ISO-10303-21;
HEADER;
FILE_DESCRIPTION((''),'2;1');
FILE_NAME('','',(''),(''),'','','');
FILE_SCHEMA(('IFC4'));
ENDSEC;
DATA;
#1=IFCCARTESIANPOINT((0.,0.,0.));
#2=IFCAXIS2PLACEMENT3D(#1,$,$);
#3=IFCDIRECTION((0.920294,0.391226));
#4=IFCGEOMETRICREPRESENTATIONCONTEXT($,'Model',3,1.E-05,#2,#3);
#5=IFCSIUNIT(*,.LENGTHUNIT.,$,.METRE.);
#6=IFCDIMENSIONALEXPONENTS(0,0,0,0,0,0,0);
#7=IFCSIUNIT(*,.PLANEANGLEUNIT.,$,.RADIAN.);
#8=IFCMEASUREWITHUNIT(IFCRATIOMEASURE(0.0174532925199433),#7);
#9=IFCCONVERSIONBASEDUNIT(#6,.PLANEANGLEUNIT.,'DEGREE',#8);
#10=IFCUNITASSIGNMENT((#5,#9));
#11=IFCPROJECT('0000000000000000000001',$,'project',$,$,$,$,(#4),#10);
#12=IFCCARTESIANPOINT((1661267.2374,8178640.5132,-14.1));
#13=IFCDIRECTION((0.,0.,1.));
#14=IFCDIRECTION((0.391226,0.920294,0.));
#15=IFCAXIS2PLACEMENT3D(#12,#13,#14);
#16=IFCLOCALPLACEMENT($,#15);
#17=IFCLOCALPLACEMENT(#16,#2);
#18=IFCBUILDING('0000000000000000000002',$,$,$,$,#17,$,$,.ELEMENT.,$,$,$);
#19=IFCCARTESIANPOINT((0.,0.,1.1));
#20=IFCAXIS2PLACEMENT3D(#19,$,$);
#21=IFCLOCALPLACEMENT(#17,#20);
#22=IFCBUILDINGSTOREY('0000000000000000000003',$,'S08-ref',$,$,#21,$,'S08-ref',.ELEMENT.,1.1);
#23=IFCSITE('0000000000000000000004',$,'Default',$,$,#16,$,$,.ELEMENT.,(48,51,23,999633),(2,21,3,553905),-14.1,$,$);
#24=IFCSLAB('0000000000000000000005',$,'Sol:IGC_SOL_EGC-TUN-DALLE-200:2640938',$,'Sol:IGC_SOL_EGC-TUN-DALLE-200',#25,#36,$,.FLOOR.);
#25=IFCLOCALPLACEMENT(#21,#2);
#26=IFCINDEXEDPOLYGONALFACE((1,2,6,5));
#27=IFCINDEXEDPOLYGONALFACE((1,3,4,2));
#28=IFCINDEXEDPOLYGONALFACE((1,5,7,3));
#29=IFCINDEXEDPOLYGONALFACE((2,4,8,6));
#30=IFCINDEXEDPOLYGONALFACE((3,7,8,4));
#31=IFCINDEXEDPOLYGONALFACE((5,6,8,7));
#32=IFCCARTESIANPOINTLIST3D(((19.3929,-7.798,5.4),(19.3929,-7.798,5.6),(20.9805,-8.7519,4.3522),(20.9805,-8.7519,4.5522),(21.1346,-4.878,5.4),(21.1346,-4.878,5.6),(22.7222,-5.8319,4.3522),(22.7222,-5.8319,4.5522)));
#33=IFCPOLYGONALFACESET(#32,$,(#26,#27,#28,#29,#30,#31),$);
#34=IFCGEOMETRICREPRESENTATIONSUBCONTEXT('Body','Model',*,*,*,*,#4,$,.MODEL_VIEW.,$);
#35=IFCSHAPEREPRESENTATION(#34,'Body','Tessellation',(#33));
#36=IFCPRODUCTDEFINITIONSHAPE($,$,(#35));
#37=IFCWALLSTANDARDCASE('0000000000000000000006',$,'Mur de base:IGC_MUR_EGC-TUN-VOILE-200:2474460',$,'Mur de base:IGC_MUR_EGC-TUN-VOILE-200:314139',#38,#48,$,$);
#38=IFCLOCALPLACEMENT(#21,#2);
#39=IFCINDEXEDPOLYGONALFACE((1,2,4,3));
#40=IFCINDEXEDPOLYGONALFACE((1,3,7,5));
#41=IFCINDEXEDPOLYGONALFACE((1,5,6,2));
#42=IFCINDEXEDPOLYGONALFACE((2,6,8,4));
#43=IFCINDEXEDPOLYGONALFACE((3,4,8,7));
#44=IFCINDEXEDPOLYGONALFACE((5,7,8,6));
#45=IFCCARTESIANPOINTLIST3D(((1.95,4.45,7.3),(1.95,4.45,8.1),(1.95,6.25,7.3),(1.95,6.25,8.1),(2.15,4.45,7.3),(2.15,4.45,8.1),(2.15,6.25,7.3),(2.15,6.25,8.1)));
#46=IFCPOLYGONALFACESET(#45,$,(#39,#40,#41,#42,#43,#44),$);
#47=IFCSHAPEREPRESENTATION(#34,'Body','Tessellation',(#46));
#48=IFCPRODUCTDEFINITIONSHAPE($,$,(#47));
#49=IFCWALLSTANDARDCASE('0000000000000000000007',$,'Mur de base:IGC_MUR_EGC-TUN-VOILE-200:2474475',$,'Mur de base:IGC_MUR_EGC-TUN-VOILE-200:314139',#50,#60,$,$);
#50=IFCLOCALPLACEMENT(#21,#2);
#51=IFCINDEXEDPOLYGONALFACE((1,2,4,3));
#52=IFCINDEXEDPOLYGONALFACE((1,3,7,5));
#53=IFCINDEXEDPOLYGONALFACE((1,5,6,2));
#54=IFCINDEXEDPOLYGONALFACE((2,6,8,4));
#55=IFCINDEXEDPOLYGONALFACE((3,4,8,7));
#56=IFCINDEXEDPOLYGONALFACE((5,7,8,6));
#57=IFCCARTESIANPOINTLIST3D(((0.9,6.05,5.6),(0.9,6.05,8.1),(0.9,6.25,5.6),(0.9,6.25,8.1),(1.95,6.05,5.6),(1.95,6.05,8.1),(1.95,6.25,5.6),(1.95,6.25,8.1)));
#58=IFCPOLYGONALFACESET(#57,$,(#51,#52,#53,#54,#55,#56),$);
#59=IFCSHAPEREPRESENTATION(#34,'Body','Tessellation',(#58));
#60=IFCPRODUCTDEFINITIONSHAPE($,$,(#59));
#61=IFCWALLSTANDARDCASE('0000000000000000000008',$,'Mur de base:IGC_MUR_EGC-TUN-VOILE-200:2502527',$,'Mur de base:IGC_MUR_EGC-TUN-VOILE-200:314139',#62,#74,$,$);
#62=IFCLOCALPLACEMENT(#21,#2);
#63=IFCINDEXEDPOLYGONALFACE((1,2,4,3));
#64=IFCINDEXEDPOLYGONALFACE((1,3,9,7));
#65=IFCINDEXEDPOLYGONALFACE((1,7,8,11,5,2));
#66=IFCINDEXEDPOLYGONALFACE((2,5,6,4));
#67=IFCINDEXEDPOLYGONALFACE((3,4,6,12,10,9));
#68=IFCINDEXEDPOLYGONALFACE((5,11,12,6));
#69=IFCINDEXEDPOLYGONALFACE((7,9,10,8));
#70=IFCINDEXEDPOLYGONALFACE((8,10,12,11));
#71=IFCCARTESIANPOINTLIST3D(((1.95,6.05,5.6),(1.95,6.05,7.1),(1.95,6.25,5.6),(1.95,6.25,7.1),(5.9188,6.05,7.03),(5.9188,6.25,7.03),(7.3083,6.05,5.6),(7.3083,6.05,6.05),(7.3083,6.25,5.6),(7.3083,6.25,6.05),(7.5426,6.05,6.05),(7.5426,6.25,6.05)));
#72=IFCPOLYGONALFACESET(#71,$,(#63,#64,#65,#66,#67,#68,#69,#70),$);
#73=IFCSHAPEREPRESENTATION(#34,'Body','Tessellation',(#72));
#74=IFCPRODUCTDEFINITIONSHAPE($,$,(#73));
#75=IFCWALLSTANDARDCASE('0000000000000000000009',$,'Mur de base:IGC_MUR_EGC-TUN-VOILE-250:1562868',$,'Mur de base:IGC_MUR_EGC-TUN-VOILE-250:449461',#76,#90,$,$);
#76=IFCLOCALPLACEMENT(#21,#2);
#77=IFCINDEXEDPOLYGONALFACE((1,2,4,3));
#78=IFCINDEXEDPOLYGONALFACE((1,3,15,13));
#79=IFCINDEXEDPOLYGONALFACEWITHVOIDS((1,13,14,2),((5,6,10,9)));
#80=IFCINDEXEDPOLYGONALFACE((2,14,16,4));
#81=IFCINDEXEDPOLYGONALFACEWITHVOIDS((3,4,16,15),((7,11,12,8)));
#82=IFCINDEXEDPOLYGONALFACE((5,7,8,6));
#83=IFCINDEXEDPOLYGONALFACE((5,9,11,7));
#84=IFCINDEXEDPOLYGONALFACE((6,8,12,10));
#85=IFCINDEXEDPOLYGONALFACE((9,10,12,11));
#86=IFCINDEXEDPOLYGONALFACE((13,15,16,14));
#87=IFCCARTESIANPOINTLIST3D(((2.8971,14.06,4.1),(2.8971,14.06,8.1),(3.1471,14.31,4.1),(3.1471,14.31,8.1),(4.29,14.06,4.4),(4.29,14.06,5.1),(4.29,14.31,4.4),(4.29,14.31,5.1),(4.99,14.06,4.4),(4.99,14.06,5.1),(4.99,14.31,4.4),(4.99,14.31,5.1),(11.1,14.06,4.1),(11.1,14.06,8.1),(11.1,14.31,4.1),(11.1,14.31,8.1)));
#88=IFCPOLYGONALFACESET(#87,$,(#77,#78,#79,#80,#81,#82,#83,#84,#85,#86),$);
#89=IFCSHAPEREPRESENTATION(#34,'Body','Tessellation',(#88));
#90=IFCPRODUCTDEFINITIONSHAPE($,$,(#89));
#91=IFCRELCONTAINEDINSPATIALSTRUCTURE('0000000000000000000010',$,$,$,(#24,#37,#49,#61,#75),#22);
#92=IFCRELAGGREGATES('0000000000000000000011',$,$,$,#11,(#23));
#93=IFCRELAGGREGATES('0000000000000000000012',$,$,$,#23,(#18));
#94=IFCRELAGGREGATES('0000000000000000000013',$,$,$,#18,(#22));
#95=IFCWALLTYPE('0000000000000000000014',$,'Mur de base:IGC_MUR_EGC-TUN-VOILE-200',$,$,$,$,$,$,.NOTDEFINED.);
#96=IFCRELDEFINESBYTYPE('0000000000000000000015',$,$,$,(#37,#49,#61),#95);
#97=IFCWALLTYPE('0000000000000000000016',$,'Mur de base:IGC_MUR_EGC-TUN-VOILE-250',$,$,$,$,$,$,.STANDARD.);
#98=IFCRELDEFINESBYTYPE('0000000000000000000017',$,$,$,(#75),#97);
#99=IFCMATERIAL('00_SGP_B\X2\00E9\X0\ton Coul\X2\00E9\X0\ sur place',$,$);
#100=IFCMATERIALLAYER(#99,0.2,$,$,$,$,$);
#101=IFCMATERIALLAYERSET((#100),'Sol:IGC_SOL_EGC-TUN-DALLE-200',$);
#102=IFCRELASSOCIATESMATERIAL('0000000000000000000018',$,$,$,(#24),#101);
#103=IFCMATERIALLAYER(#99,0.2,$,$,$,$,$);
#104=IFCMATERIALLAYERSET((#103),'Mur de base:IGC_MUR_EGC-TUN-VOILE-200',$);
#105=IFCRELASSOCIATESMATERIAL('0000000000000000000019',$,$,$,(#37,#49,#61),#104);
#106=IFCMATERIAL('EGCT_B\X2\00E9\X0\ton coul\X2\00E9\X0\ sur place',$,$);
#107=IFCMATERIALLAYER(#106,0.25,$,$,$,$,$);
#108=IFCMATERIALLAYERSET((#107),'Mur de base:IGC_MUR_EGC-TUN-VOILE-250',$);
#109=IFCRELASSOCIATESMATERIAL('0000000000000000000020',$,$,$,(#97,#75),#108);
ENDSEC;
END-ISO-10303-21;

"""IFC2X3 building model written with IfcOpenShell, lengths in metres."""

from ifc_helpers import new_model, entity, si_unit, converted_unit, direction, frame, frame_2d, origin, place, context, subcontext, project, spatial, polyline, rectangle, outline, extrude, clip, halfspace, bounded_halfspace, material, layer, layer_set, layer_usage, type_object, element, save


model = new_model("IFC2X3")

# Units and contexts
model_context = context("Model", 3, precision=1e-05, world=origin(), true_north=direction((0.920294, 0.391226)))
body_context = subcontext(model_context, "Body", "Model", "MODEL_VIEW")
ifc_project = project(units=[si_unit("LENGTHUNIT", "METRE"), converted_unit("PLANEANGLEUNIT", "DEGREE", entity("IfcRatioMeasure", 0.0174532925199433), si_unit("PLANEANGLEUNIT", "RADIAN"), dimensions=[0, 0, 0, 0, 0, 0, 0])], contexts=[model_context])

# Site, building, storey
site_placement = place(None, frame((1661267.2374, 8178640.5132, -14.1), z_axis=(0.0, 0.0, 1.0), x_axis=(0.391226, 0.920294, 0.0)))
site = spatial("IfcSite", under=ifc_project, at=site_placement, Name="Default", CompositionType="ELEMENT", RefLatitude=(48, 51, 23, 999633), RefLongitude=(2, 21, 3, 553905), RefElevation=-14.1)
building_placement = place(site_placement, origin())
building = spatial("IfcBuilding", under=site, at=building_placement, CompositionType="ELEMENT")
storey_placement = place(building_placement, frame((0.0, 0.0, 1.1)))
storey = spatial("IfcBuildingStorey", under=building, at=storey_placement, Name="S08-ref", LongName="S08-ref", CompositionType="ELEMENT", Elevation=1.1)

# Slab
ifc_material_1 = material(Name="00_SGP_Béton Coulé sur place")
ifc_layer_1 = layer(ifc_material_1, 0.2)
ifc_layer_set_1 = layer_set([ifc_layer_1], Name="Sol:IGC_SOL_EGC-TUN-DALLE-200")
ifc_layer_usage_1 = layer_usage(ifc_layer_set_1, "AXIS3", "POSITIVE", 0.0)
slab_1_placement = place(storey_placement, origin())
element("IfcSlab", 1, at=slab_1_placement, inside=storey, material=ifc_layer_usage_1, Name="Sol:IGC_SOL_EGC-TUN-DALLE-200:2640938", ObjectType="Sol:IGC_SOL_EGC-TUN-DALLE-200", PredefinedType="FLOOR", context=body_context, shape_type="Clipping", body=[
    clip(clip(extrude(outline(polyline([(-1.697, -1.064), (1.703, -1.064), (1.697, 1.064), (-1.703, 1.064), (-1.697, -1.064)])), frame((21.0576, -6.815, 5.0761), z_axis=(-0.422885, 0.252242, -0.870369), x_axis=(-0.51227, -0.858824, 0.0)), (0.0, -0.4924, 0.870369), 0.2298), halfspace(frame((21.0576, -6.815, 4.8761), z_axis=(-0.422885, 0.252242, -0.870369), x_axis=(-0.746053, 0.448274, 0.492398)), False)), halfspace(frame((21.0576, -6.815, 5.0761), z_axis=(0.422885, -0.252242, 0.870369), x_axis=(-0.746053, 0.448274, 0.492398)), False)),
])

# Shared definitions
ifc_layer_2 = layer(ifc_material_1, 0.2)
ifc_layer_set_2 = layer_set([ifc_layer_2], Name="Mur de base:IGC_MUR_EGC-TUN-VOILE-200")
wall_type_1 = type_object("IfcWallType", Name="Mur de base:IGC_MUR_EGC-TUN-VOILE-200", PredefinedType="NOTDEFINED")

# Walls
ifc_layer_usage_2 = layer_usage(ifc_layer_set_2, "AXIS2", "NEGATIVE", 0.1)
wall_1_placement = place(storey_placement, frame((2.05, 4.45, 7.3), z_axis=(0.0, 0.0, 1.0), x_axis=(0.0, 1.0, 0.0)))
element("IfcWallStandardCase", 2, at=wall_1_placement, inside=storey, type_object=wall_type_1, material=ifc_layer_usage_2, Name="Mur de base:IGC_MUR_EGC-TUN-VOILE-200:2474460", ObjectType="Mur de base:IGC_MUR_EGC-TUN-VOILE-200:314139", context=body_context, shape_type="SweptSolid", body=[
    extrude(rectangle(XDim=1.8, YDim=0.2, at=frame_2d((0.9, 0.0), x_axis=(-1.0, 0.0))), origin(), (0.0, 0.0, 1.0), 0.8),
])
ifc_layer_usage_3 = layer_usage(ifc_layer_set_2, "AXIS2", "NEGATIVE", 0.1)
wall_2_placement = place(storey_placement, frame((1.95, 6.15, 5.6), z_axis=(0.0, 0.0, 1.0), x_axis=(-1.0, 0.0, 0.0)))
element("IfcWallStandardCase", 3, at=wall_2_placement, inside=storey, type_object=wall_type_1, material=ifc_layer_usage_3, Name="Mur de base:IGC_MUR_EGC-TUN-VOILE-200:2474475", ObjectType="Mur de base:IGC_MUR_EGC-TUN-VOILE-200:314139", context=body_context, shape_type="SweptSolid", body=[
    extrude(rectangle(XDim=1.05, YDim=0.2, at=frame_2d((0.525, 0.0), x_axis=(-1.0, 0.0))), origin(), (0.0, 0.0, 1.0), 2.5),
])
ifc_layer_usage_4 = layer_usage(ifc_layer_set_2, "AXIS2", "NEGATIVE", 0.1)
wall_3_placement = place(storey_placement, frame((7.5426, 6.15, 5.6), z_axis=(0.0, 0.0, 1.0), x_axis=(-1.0, 0.0, 0.0)))
element("IfcWallStandardCase", 4, at=wall_3_placement, inside=storey, type_object=wall_type_1, material=ifc_layer_usage_4, Name="Mur de base:IGC_MUR_EGC-TUN-VOILE-200:2502527", ObjectType="Mur de base:IGC_MUR_EGC-TUN-VOILE-200:314139", context=body_context, shape_type="Clipping", body=[
    clip(clip(clip(clip(extrude(rectangle(XDim=5.5926, YDim=0.2, at=frame_2d((2.7963, 0.0), x_axis=(-1.0, 0.0))), origin(), (0.0, 0.0, 1.0), 1.5), bounded_halfspace(frame((0.2343, -0.1, 0.45), z_axis=(1.0, 0.0, 0.0), x_axis=(0.0, -1.0, 0.0)), True, frame((0.2343, -0.1, 0.45), z_axis=(1.0, 0.0, 0.0), x_axis=(0.0, -1.0, 0.0)), polyline([(0.0, 0.0), (0.0, 0.45), (-0.2, 0.45), (-0.2, 0.0), (0.0, 0.0)]))), bounded_halfspace(frame((0.2343, 0.1, 0.45), z_axis=(0.0, 0.0, 1.0), x_axis=(0.0, -1.0, 0.0)), True, frame((0.2343, 0.1, 0.45), z_axis=(0.0, 0.0, 1.0), x_axis=(0.0, -1.0, 0.0)), polyline([(0.0, 0.0), (0.0, -0.2343), (0.2, -0.2343), (0.2, 0.0), (0.0, 0.0)]))), halfspace(frame((1.6238, -0.1, 1.43), z_axis=(-0.017635, 0.0, 0.999844), x_axis=(0.0, 1.0, 0.0)), False)), halfspace(frame((1.6238, -0.1, 1.43), z_axis=(-0.516703, 0.0, 0.856165), x_axis=(0.0, 1.0, 0.0)), False)),
])

# Wall, opening
ifc_material_2 = material(Name="EGCT_Béton coulé sur place")
ifc_layer_3 = layer(ifc_material_2, 0.25)
ifc_layer_set_3 = layer_set([ifc_layer_3], Name="Mur de base:IGC_MUR_EGC-TUN-VOILE-250")
ifc_layer_usage_5 = layer_usage(ifc_layer_set_3, "AXIS2", "NEGATIVE", 0.125)
wall_type_2 = type_object("IfcWallType", Name="Mur de base:IGC_MUR_EGC-TUN-VOILE-250", PredefinedType="STANDARD", material=ifc_layer_set_3)
wall_4_placement = place(storey_placement, frame((2.8971, 14.185, 4.1)))
wall_4 = element("IfcWallStandardCase", 5, at=wall_4_placement, inside=storey, type_object=wall_type_2, material=ifc_layer_usage_5, Name="Mur de base:IGC_MUR_EGC-TUN-VOILE-250:1562868", ObjectType="Mur de base:IGC_MUR_EGC-TUN-VOILE-250:449461", context=body_context, shape_type="Clipping", body=[
    clip(extrude(rectangle(XDim=8.2029, YDim=0.25, at=frame_2d((4.1015, 0.0), x_axis=(-1.0, 0.0))), origin(), (0.0, 0.0, 1.0), 4.0), bounded_halfspace(frame((0.0, -0.125, 0.0), z_axis=(0.707107, -0.707107, 0.0), x_axis=(0.0, 0.0, 1.0)), True, frame((0.0, -0.125, 0.0), z_axis=(0.707107, -0.707107, 0.0), x_axis=(0.0, 0.0, 1.0)), polyline([(0.0, 0.0), (0.0, -0.3536), (4.0, -0.3536), (4.0, 0.0), (0.0, 0.0)]))),
])
opening_1_placement = place(wall_4_placement, origin())
element("IfcOpeningElement", 6, at=opening_1_placement, cuts=wall_4, ObjectType="Opening", context=body_context, shape_type="SweptSolid", body=[
    extrude(rectangle(XDim=0.7, YDim=0.7, at=frame_2d((0.0, 0.0), x_axis=(0.0, 1.0))), frame((1.7429, -1.6493, 0.65), z_axis=(0.0, 1.0, 0.0), x_axis=(1.0, 0.0, 0.0)), (0.0, 0.0, 1.0), 3.048),
])

save(model, "model.ifc")
